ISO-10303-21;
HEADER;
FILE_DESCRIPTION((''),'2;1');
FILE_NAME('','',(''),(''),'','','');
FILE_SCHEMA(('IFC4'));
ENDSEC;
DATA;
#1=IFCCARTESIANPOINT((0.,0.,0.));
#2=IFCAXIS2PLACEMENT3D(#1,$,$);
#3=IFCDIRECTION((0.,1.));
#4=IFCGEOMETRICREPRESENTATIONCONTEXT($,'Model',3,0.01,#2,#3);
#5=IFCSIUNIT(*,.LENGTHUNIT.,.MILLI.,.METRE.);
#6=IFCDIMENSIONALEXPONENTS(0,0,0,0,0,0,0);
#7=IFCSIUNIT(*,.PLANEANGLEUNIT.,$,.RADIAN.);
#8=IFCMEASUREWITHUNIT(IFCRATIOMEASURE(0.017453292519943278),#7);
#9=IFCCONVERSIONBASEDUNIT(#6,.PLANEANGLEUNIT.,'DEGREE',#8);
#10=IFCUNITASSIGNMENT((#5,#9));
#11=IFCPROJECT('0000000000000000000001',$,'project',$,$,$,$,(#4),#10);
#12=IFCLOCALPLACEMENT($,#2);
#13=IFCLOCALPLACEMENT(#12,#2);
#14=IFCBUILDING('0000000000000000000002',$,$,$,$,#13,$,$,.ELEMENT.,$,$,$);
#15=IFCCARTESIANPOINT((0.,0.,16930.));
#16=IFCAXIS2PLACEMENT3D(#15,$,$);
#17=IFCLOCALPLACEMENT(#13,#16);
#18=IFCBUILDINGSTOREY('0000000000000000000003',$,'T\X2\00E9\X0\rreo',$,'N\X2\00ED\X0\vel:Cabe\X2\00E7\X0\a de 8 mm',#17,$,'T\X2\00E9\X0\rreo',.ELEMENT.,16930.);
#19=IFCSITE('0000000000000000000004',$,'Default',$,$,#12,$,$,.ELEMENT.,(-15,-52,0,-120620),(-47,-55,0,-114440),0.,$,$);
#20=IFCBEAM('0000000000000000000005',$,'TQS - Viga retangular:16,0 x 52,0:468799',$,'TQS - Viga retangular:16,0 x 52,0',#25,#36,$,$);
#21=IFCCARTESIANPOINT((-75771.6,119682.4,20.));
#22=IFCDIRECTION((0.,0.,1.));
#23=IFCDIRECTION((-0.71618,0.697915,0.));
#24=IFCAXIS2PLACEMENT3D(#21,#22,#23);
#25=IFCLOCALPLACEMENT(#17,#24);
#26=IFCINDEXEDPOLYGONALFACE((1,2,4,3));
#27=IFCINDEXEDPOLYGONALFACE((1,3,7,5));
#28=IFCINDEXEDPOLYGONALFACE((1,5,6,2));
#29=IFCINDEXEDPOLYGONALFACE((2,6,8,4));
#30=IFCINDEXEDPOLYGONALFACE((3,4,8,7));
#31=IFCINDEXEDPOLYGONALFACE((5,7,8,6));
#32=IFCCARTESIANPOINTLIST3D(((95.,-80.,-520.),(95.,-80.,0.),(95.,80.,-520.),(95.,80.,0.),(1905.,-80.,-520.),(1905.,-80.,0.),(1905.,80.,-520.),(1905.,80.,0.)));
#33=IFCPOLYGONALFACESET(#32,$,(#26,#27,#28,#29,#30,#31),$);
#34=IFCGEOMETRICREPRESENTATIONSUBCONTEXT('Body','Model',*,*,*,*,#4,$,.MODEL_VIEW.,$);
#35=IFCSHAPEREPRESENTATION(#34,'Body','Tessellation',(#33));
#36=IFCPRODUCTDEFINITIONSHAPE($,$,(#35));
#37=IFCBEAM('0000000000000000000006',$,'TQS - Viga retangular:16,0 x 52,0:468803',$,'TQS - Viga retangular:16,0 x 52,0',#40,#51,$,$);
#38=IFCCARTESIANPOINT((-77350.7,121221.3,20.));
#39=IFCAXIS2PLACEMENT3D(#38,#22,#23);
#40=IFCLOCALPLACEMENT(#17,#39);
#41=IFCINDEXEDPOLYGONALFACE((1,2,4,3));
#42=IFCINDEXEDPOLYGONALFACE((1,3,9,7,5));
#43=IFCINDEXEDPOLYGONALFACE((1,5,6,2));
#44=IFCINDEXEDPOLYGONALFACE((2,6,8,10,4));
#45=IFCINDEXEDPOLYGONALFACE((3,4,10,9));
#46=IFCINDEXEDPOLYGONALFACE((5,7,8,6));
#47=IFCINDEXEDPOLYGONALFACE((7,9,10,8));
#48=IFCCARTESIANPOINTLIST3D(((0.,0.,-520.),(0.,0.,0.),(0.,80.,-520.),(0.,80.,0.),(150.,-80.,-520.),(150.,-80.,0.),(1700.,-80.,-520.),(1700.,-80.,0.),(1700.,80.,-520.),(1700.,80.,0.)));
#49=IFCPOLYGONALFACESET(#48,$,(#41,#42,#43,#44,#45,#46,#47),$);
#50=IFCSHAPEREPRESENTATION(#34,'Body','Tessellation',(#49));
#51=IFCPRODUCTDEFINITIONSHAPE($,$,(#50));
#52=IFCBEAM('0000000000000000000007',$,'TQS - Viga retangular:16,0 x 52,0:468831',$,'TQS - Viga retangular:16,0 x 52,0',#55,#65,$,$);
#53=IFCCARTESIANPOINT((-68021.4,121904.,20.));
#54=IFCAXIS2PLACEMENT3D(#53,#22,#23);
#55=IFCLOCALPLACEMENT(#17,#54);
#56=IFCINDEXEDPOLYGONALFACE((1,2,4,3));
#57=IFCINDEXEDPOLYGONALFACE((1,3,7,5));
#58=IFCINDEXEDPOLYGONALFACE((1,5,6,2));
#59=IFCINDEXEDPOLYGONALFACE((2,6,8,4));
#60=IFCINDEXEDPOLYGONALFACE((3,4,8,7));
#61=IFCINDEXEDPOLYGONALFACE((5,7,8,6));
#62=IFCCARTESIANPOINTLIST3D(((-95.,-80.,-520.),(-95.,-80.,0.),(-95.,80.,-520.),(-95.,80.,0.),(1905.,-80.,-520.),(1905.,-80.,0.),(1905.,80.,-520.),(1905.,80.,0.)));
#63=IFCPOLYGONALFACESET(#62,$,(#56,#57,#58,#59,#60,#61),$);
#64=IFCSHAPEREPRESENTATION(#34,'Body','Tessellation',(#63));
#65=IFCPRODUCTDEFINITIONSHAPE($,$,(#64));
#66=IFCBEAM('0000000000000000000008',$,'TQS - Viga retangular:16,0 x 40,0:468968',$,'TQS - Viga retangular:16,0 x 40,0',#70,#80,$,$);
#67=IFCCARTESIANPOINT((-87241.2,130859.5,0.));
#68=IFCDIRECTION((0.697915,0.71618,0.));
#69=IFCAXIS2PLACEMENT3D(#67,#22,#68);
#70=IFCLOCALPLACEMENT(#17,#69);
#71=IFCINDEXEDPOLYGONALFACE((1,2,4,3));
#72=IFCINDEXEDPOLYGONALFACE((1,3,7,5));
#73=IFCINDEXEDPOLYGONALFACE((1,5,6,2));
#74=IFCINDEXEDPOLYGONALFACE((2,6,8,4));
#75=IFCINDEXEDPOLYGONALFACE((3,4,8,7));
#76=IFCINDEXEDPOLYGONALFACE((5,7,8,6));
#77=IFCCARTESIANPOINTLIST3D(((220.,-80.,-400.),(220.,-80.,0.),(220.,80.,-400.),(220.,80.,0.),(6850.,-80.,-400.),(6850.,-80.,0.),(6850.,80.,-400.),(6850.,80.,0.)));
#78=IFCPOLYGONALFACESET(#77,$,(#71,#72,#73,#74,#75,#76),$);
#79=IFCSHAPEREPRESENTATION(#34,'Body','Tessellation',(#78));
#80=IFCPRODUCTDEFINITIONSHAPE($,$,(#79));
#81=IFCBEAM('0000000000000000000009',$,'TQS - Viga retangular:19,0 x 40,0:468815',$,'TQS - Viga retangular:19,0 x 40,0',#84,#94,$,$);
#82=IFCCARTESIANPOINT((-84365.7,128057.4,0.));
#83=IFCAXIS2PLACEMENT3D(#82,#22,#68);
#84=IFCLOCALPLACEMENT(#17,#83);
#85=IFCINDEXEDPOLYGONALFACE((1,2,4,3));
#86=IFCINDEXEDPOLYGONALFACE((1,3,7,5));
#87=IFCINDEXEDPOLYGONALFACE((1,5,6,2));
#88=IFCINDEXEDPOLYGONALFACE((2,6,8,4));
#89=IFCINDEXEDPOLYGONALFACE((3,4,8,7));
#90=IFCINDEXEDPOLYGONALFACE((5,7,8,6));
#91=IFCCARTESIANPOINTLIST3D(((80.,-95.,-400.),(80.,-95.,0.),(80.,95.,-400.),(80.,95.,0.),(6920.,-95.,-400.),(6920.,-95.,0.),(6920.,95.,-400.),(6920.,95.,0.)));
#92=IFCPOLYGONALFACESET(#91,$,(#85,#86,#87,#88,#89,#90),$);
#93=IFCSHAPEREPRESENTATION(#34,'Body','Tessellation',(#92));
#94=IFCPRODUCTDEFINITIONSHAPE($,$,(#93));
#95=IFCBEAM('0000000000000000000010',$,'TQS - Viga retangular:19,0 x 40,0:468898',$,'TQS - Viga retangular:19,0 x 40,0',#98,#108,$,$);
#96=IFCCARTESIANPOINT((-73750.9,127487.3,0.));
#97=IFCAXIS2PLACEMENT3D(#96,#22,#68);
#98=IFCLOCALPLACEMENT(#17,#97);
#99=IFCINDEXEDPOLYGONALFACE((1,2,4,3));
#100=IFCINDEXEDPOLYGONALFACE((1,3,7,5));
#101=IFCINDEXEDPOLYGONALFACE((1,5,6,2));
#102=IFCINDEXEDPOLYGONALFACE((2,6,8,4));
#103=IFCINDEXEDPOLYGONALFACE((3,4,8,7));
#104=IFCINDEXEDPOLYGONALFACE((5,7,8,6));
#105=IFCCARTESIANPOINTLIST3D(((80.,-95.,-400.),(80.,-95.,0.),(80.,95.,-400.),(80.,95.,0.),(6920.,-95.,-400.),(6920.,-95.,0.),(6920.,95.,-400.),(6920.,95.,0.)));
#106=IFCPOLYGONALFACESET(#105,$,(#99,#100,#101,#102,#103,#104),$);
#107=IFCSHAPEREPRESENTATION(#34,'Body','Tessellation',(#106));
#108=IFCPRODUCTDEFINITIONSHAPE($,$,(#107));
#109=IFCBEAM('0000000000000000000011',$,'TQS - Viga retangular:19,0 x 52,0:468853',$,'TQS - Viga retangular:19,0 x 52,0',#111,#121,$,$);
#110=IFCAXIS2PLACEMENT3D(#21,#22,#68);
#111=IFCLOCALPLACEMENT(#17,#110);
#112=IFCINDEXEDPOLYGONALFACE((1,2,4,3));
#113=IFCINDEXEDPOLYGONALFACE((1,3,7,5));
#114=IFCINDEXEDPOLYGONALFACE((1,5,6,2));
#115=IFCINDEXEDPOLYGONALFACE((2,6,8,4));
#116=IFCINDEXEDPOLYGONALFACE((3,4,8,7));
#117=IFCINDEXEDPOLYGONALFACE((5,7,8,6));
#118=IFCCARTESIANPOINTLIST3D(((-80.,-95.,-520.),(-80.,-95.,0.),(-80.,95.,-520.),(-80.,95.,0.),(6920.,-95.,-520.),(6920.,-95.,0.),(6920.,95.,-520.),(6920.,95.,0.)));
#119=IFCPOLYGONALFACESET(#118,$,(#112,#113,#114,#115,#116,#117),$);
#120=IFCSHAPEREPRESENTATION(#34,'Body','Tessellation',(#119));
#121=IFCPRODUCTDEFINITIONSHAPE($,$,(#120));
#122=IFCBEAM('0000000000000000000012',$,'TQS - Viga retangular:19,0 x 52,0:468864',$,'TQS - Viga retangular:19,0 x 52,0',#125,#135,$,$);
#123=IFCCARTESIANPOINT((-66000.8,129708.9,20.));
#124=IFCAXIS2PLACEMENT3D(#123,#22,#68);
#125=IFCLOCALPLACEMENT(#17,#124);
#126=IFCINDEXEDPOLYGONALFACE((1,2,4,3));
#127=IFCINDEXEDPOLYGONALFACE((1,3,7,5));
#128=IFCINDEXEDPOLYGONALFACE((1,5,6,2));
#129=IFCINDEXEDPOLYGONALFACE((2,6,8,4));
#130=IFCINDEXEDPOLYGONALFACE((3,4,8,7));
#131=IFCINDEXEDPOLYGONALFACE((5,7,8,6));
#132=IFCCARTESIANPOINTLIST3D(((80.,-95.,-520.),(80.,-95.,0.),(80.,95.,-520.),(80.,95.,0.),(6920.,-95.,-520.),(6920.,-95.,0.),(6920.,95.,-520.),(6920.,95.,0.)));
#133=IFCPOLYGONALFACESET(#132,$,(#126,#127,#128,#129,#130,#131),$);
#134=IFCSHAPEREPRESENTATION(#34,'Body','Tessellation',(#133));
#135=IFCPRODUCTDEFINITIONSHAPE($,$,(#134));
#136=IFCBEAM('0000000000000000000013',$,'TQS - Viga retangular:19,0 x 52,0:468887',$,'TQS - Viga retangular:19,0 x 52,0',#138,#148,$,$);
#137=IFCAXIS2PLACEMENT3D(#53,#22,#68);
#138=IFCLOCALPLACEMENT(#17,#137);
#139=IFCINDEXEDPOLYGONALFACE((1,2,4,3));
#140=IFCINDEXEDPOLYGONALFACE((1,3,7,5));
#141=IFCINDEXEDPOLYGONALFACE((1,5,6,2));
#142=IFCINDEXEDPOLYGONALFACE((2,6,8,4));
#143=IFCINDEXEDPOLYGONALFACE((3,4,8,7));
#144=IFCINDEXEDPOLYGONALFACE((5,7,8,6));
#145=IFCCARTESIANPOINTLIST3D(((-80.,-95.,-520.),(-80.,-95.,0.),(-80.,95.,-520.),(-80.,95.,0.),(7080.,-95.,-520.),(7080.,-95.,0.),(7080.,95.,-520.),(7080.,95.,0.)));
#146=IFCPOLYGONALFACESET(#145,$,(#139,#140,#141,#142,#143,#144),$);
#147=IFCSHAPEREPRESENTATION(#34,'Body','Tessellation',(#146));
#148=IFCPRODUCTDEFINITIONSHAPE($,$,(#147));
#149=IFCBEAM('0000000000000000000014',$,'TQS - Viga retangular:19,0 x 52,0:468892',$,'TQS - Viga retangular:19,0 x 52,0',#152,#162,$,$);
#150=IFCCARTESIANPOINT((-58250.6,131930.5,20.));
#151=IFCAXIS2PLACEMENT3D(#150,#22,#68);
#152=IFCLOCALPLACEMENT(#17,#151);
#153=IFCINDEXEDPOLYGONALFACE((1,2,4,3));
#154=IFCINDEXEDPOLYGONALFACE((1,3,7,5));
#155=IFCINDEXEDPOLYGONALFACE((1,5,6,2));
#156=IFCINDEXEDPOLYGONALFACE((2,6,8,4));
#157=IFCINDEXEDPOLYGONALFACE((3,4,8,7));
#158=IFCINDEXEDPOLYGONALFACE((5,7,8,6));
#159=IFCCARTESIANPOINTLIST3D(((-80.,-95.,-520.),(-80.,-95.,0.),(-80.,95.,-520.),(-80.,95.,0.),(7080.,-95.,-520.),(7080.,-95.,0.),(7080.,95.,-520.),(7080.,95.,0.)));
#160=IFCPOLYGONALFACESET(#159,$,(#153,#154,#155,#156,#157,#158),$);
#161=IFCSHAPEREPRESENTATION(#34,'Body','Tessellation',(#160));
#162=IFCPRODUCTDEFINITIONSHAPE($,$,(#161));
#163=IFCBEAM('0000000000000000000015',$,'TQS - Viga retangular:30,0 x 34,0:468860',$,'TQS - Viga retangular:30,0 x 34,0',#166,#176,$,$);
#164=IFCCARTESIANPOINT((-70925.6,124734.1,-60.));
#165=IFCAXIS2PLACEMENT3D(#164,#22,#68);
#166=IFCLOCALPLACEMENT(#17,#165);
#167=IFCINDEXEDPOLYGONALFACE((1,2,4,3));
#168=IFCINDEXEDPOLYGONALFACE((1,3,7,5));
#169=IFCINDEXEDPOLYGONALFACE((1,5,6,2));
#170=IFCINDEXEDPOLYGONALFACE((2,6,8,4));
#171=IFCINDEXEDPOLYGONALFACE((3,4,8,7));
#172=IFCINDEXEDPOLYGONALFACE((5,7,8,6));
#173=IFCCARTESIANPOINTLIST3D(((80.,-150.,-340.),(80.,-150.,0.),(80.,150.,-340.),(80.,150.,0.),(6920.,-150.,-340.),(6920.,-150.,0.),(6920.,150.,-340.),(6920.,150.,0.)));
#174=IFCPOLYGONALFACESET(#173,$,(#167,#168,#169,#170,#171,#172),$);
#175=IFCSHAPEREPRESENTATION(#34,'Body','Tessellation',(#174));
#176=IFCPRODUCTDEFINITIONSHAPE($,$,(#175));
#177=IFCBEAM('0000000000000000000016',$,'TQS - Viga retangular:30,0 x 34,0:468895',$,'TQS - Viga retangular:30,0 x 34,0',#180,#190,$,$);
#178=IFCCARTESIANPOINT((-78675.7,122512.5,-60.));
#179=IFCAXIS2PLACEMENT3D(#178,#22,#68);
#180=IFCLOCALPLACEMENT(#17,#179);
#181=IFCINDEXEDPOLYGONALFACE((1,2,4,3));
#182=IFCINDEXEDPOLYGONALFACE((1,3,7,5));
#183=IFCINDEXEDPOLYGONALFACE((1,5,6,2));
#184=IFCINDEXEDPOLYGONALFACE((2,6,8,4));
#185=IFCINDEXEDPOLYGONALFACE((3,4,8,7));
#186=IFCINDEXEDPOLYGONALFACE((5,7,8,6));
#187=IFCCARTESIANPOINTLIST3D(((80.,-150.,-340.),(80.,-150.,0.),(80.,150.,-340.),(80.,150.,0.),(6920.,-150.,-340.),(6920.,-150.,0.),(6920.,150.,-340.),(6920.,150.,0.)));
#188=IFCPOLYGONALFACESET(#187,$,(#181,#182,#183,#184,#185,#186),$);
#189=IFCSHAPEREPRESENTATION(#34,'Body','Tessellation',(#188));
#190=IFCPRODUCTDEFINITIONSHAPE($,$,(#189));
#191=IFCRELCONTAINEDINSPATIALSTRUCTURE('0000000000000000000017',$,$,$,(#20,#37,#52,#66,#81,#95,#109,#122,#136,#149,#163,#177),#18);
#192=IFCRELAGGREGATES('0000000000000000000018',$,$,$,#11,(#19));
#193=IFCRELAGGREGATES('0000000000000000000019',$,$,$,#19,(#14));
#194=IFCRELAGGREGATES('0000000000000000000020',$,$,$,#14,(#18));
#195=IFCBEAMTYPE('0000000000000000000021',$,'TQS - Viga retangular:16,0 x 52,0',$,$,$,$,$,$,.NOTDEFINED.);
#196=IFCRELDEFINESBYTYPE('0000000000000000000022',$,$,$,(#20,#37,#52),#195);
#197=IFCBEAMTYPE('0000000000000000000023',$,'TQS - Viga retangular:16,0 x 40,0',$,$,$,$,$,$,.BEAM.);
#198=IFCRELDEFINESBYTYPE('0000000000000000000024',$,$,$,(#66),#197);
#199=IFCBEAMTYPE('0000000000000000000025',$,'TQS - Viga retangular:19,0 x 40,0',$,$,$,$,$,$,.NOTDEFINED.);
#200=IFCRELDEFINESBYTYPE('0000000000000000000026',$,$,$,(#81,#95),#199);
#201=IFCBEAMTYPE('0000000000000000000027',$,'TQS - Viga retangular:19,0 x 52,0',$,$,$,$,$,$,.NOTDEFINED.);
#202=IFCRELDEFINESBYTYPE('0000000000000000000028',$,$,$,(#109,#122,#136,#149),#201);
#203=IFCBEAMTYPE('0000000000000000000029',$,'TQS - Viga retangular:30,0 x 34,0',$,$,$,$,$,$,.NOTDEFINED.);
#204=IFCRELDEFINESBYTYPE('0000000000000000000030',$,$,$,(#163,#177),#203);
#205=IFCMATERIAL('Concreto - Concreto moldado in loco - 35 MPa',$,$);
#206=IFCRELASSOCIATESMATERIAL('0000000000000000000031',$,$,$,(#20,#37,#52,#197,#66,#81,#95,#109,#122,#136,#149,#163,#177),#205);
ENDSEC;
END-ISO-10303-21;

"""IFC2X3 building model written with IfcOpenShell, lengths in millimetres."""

from ifc_helpers import new_model, entity, si_unit, converted_unit, direction, frame, frame_2d, origin, origin_2d_with_axis, place, context, subcontext, project, spatial, rectangle, extrude, clip, halfspace, material, type_object, element, save


model = new_model("IFC2X3")

# Units and contexts
model_context = context("Model", 3, precision=0.01, world=origin(), true_north=direction((0.0, 1.0)))
body_context = subcontext(model_context, "Body", "Model", "MODEL_VIEW")
ifc_project = project(units=[si_unit("LENGTHUNIT", "METRE", prefix="MILLI"), converted_unit("PLANEANGLEUNIT", "DEGREE", entity("IfcRatioMeasure", 0.017453292519943278), si_unit("PLANEANGLEUNIT", "RADIAN"), dimensions=[0, 0, 0, 0, 0, 0, 0])], contexts=[model_context])

# Site, building, storey
site_placement = place(None, origin())
site = spatial("IfcSite", under=ifc_project, at=site_placement, Name="Default", CompositionType="ELEMENT", RefLatitude=(-15, -52, 0, -120620), RefLongitude=(-47, -55, 0, -114440), RefElevation=0.0)
building_placement = place(site_placement, origin())
building = spatial("IfcBuilding", under=site, at=building_placement, CompositionType="ELEMENT")
storey_placement = place(building_placement, frame((0.0, 0.0, 16930.0)))
storey = spatial("IfcBuildingStorey", under=building, at=storey_placement, Name="Térreo", ObjectType="Nível:Cabeça de 8 mm", LongName="Térreo", CompositionType="ELEMENT", Elevation=16930.0)

# Beams
ifc_material_1 = material(Name="Concreto - Concreto moldado in loco - 35 MPa")
beam_type_1 = type_object("IfcBeamType", Name="TQS - Viga retangular:16,0 x 52,0", PredefinedType="NOTDEFINED")
beam_1_placement = place(storey_placement, frame((-75771.6, 119682.4, 20.0), z_axis=(0.0, 0.0, 1.0), x_axis=(-0.71618, 0.697915, 0.0)))
element("IfcBeam", 1, at=beam_1_placement, inside=storey, type_object=beam_type_1, material=ifc_material_1, Name="TQS - Viga retangular:16,0 x 52,0:468799", ObjectType="TQS - Viga retangular:16,0 x 52,0", context=body_context, shape_type="SweptSolid", body=[
    extrude(rectangle(XDim=520.0, YDim=160.0, at=frame_2d((0.0, 0.0), x_axis=(1.0, 0.0))), frame((95.0, 0.0, -260.0), z_axis=(1.0, 0.0, 0.0), x_axis=(0.0, 0.0, -1.0)), (0.0, 0.0, 1.0), 1810.0),
])
beam_2_placement = place(storey_placement, frame((-77350.7, 121221.3, 20.0), z_axis=(0.0, 0.0, 1.0), x_axis=(-0.71618, 0.697915, 0.0)))
element("IfcBeam", 2, at=beam_2_placement, inside=storey, type_object=beam_type_1, material=ifc_material_1, Name="TQS - Viga retangular:16,0 x 52,0:468803", ObjectType="TQS - Viga retangular:16,0 x 52,0", context=body_context, shape_type="SweptSolid", body=[
    clip(extrude(rectangle(XDim=520.0, YDim=160.0, at=frame_2d((0.0, 0.0), x_axis=(1.0, 0.0))), frame((0.0, 0.0, -260.0), z_axis=(1.0, 0.0, 0.0), x_axis=(0.0, 0.0, -1.0)), (0.0, 0.0, 1.0), 1700.0), halfspace(frame((150.0, -80.0, 0.0), z_axis=(-0.470588, -0.882353, 0.0), x_axis=(-0.882353, 0.470588, 0.0)), False)),
])
beam_3_placement = place(storey_placement, frame((-68021.4, 121904.0, 20.0), z_axis=(0.0, 0.0, 1.0), x_axis=(-0.71618, 0.697915, 0.0)))
element("IfcBeam", 3, at=beam_3_placement, inside=storey, type_object=beam_type_1, material=ifc_material_1, Name="TQS - Viga retangular:16,0 x 52,0:468831", ObjectType="TQS - Viga retangular:16,0 x 52,0", context=body_context, shape_type="SweptSolid", body=[
    extrude(rectangle(XDim=520.0, YDim=160.0, at=frame_2d((0.0, 0.0), x_axis=(1.0, 0.0))), frame((-95.0, 0.0, -260.0), z_axis=(1.0, 0.0, 0.0), x_axis=(0.0, 0.0, -1.0)), (0.0, 0.0, 1.0), 2000.0),
])
beam_type_2 = type_object("IfcBeamType", Name="TQS - Viga retangular:16,0 x 40,0", PredefinedType="BEAM", material=ifc_material_1)
beam_4_placement = place(storey_placement, frame((-87241.2, 130859.5, 0.0), z_axis=(0.0, 0.0, 1.0), x_axis=(0.697915, 0.71618, 0.0)))
element("IfcBeam", 4, at=beam_4_placement, inside=storey, type_object=beam_type_2, material=ifc_material_1, Name="TQS - Viga retangular:16,0 x 40,0:468968", ObjectType="TQS - Viga retangular:16,0 x 40,0", context=body_context, shape_type="SweptSolid", body=[
    extrude(rectangle(XDim=400.0, YDim=160.0, at=frame_2d((0.0, 0.0), x_axis=(1.0, 0.0))), frame((220.0, 0.0, -200.0), z_axis=(1.0, 0.0, 0.0), x_axis=(0.0, 0.0, -1.0)), (0.0, 0.0, 1.0), 6630.0),
])
beam_type_3 = type_object("IfcBeamType", Name="TQS - Viga retangular:19,0 x 40,0", PredefinedType="NOTDEFINED")
beam_5_placement = place(storey_placement, frame((-84365.7, 128057.4, 0.0), z_axis=(0.0, 0.0, 1.0), x_axis=(0.697915, 0.71618, 0.0)))
element("IfcBeam", 5, at=beam_5_placement, inside=storey, type_object=beam_type_3, material=ifc_material_1, Name="TQS - Viga retangular:19,0 x 40,0:468815", ObjectType="TQS - Viga retangular:19,0 x 40,0", context=body_context, shape_type="SweptSolid", body=[
    extrude(rectangle(XDim=400.0, YDim=190.0, at=origin_2d_with_axis()), frame((80.0, 0.0, -200.0), z_axis=(1.0, 0.0, 0.0), x_axis=(0.0, 0.0, -1.0)), (0.0, 0.0, 1.0), 6840.0),
])
beam_6_placement = place(storey_placement, frame((-73750.9, 127487.3, 0.0), z_axis=(0.0, 0.0, 1.0), x_axis=(0.697915, 0.71618, 0.0)))
element("IfcBeam", 6, at=beam_6_placement, inside=storey, type_object=beam_type_3, material=ifc_material_1, Name="TQS - Viga retangular:19,0 x 40,0:468898", ObjectType="TQS - Viga retangular:19,0 x 40,0", context=body_context, shape_type="SweptSolid", body=[
    extrude(rectangle(XDim=400.0, YDim=190.0, at=origin_2d_with_axis()), frame((80.0, 0.0, -200.0), z_axis=(1.0, 0.0, 0.0), x_axis=(0.0, 0.0, -1.0)), (0.0, 0.0, 1.0), 6840.0),
])
beam_type_4 = type_object("IfcBeamType", Name="TQS - Viga retangular:19,0 x 52,0", PredefinedType="NOTDEFINED")
beam_7_placement = place(storey_placement, frame((-75771.6, 119682.4, 20.0), z_axis=(0.0, 0.0, 1.0), x_axis=(0.697915, 0.71618, 0.0)))
element("IfcBeam", 7, at=beam_7_placement, inside=storey, type_object=beam_type_4, material=ifc_material_1, Name="TQS - Viga retangular:19,0 x 52,0:468853", ObjectType="TQS - Viga retangular:19,0 x 52,0", context=body_context, shape_type="SweptSolid", body=[
    extrude(rectangle(XDim=520.0, YDim=190.0, at=frame_2d((0.0, 0.0), x_axis=(1.0, 0.0))), frame((-80.0, 0.0, -260.0), z_axis=(1.0, 0.0, 0.0), x_axis=(0.0, 0.0, -1.0)), (0.0, 0.0, 1.0), 7000.0),
])
beam_8_placement = place(storey_placement, frame((-66000.8, 129708.9, 20.0), z_axis=(0.0, 0.0, 1.0), x_axis=(0.697915, 0.71618, 0.0)))
element("IfcBeam", 8, at=beam_8_placement, inside=storey, type_object=beam_type_4, material=ifc_material_1, Name="TQS - Viga retangular:19,0 x 52,0:468864", ObjectType="TQS - Viga retangular:19,0 x 52,0", context=body_context, shape_type="SweptSolid", body=[
    extrude(rectangle(XDim=520.0, YDim=190.0, at=frame_2d((0.0, 0.0), x_axis=(1.0, 0.0))), frame((80.0, 0.0, -260.0), z_axis=(1.0, 0.0, 0.0), x_axis=(0.0, 0.0, -1.0)), (0.0, 0.0, 1.0), 6840.0),
])
beam_9_placement = place(storey_placement, frame((-68021.4, 121904.0, 20.0), z_axis=(0.0, 0.0, 1.0), x_axis=(0.697915, 0.71618, 0.0)))
element("IfcBeam", 9, at=beam_9_placement, inside=storey, type_object=beam_type_4, material=ifc_material_1, Name="TQS - Viga retangular:19,0 x 52,0:468887", ObjectType="TQS - Viga retangular:19,0 x 52,0", context=body_context, shape_type="SweptSolid", body=[
    extrude(rectangle(XDim=520.0, YDim=190.0, at=frame_2d((0.0, 0.0), x_axis=(1.0, 0.0))), frame((-80.0, 0.0, -260.0), z_axis=(1.0, 0.0, 0.0), x_axis=(0.0, 0.0, -1.0)), (0.0, 0.0, 1.0), 7160.0),
])
beam_10_placement = place(storey_placement, frame((-58250.6, 131930.5, 20.0), z_axis=(0.0, 0.0, 1.0), x_axis=(0.697915, 0.71618, 0.0)))
element("IfcBeam", 10, at=beam_10_placement, inside=storey, type_object=beam_type_4, material=ifc_material_1, Name="TQS - Viga retangular:19,0 x 52,0:468892", ObjectType="TQS - Viga retangular:19,0 x 52,0", context=body_context, shape_type="SweptSolid", body=[
    extrude(rectangle(XDim=520.0, YDim=190.0, at=frame_2d((0.0, 0.0), x_axis=(1.0, 0.0))), frame((-80.0, 0.0, -260.0), z_axis=(1.0, 0.0, 0.0), x_axis=(0.0, 0.0, -1.0)), (0.0, 0.0, 1.0), 7160.0),
])
beam_type_5 = type_object("IfcBeamType", Name="TQS - Viga retangular:30,0 x 34,0", PredefinedType="NOTDEFINED")
beam_11_placement = place(storey_placement, frame((-70925.6, 124734.1, -60.0), z_axis=(0.0, 0.0, 1.0), x_axis=(0.697915, 0.71618, 0.0)))
element("IfcBeam", 11, at=beam_11_placement, inside=storey, type_object=beam_type_5, material=ifc_material_1, Name="TQS - Viga retangular:30,0 x 34,0:468860", ObjectType="TQS - Viga retangular:30,0 x 34,0", context=body_context, shape_type="SweptSolid", body=[
    extrude(rectangle(XDim=340.0, YDim=300.0, at=frame_2d((0.0, 0.0), x_axis=(1.0, 0.0))), frame((80.0, 0.0, -170.0), z_axis=(1.0, 0.0, 0.0), x_axis=(0.0, 0.0, -1.0)), (0.0, 0.0, 1.0), 6840.0),
])
beam_12_placement = place(storey_placement, frame((-78675.7, 122512.5, -60.0), z_axis=(0.0, 0.0, 1.0), x_axis=(0.697915, 0.71618, 0.0)))
element("IfcBeam", 12, at=beam_12_placement, inside=storey, type_object=beam_type_5, material=ifc_material_1, Name="TQS - Viga retangular:30,0 x 34,0:468895", ObjectType="TQS - Viga retangular:30,0 x 34,0", context=body_context, shape_type="SweptSolid", body=[
    extrude(rectangle(XDim=340.0, YDim=300.0, at=frame_2d((0.0, 0.0), x_axis=(1.0, 0.0))), frame((80.0, 0.0, -170.0), z_axis=(1.0, 0.0, 0.0), x_axis=(0.0, 0.0, -1.0)), (0.0, 0.0, 1.0), 6840.0),
])

save(model, "model.ifc")
